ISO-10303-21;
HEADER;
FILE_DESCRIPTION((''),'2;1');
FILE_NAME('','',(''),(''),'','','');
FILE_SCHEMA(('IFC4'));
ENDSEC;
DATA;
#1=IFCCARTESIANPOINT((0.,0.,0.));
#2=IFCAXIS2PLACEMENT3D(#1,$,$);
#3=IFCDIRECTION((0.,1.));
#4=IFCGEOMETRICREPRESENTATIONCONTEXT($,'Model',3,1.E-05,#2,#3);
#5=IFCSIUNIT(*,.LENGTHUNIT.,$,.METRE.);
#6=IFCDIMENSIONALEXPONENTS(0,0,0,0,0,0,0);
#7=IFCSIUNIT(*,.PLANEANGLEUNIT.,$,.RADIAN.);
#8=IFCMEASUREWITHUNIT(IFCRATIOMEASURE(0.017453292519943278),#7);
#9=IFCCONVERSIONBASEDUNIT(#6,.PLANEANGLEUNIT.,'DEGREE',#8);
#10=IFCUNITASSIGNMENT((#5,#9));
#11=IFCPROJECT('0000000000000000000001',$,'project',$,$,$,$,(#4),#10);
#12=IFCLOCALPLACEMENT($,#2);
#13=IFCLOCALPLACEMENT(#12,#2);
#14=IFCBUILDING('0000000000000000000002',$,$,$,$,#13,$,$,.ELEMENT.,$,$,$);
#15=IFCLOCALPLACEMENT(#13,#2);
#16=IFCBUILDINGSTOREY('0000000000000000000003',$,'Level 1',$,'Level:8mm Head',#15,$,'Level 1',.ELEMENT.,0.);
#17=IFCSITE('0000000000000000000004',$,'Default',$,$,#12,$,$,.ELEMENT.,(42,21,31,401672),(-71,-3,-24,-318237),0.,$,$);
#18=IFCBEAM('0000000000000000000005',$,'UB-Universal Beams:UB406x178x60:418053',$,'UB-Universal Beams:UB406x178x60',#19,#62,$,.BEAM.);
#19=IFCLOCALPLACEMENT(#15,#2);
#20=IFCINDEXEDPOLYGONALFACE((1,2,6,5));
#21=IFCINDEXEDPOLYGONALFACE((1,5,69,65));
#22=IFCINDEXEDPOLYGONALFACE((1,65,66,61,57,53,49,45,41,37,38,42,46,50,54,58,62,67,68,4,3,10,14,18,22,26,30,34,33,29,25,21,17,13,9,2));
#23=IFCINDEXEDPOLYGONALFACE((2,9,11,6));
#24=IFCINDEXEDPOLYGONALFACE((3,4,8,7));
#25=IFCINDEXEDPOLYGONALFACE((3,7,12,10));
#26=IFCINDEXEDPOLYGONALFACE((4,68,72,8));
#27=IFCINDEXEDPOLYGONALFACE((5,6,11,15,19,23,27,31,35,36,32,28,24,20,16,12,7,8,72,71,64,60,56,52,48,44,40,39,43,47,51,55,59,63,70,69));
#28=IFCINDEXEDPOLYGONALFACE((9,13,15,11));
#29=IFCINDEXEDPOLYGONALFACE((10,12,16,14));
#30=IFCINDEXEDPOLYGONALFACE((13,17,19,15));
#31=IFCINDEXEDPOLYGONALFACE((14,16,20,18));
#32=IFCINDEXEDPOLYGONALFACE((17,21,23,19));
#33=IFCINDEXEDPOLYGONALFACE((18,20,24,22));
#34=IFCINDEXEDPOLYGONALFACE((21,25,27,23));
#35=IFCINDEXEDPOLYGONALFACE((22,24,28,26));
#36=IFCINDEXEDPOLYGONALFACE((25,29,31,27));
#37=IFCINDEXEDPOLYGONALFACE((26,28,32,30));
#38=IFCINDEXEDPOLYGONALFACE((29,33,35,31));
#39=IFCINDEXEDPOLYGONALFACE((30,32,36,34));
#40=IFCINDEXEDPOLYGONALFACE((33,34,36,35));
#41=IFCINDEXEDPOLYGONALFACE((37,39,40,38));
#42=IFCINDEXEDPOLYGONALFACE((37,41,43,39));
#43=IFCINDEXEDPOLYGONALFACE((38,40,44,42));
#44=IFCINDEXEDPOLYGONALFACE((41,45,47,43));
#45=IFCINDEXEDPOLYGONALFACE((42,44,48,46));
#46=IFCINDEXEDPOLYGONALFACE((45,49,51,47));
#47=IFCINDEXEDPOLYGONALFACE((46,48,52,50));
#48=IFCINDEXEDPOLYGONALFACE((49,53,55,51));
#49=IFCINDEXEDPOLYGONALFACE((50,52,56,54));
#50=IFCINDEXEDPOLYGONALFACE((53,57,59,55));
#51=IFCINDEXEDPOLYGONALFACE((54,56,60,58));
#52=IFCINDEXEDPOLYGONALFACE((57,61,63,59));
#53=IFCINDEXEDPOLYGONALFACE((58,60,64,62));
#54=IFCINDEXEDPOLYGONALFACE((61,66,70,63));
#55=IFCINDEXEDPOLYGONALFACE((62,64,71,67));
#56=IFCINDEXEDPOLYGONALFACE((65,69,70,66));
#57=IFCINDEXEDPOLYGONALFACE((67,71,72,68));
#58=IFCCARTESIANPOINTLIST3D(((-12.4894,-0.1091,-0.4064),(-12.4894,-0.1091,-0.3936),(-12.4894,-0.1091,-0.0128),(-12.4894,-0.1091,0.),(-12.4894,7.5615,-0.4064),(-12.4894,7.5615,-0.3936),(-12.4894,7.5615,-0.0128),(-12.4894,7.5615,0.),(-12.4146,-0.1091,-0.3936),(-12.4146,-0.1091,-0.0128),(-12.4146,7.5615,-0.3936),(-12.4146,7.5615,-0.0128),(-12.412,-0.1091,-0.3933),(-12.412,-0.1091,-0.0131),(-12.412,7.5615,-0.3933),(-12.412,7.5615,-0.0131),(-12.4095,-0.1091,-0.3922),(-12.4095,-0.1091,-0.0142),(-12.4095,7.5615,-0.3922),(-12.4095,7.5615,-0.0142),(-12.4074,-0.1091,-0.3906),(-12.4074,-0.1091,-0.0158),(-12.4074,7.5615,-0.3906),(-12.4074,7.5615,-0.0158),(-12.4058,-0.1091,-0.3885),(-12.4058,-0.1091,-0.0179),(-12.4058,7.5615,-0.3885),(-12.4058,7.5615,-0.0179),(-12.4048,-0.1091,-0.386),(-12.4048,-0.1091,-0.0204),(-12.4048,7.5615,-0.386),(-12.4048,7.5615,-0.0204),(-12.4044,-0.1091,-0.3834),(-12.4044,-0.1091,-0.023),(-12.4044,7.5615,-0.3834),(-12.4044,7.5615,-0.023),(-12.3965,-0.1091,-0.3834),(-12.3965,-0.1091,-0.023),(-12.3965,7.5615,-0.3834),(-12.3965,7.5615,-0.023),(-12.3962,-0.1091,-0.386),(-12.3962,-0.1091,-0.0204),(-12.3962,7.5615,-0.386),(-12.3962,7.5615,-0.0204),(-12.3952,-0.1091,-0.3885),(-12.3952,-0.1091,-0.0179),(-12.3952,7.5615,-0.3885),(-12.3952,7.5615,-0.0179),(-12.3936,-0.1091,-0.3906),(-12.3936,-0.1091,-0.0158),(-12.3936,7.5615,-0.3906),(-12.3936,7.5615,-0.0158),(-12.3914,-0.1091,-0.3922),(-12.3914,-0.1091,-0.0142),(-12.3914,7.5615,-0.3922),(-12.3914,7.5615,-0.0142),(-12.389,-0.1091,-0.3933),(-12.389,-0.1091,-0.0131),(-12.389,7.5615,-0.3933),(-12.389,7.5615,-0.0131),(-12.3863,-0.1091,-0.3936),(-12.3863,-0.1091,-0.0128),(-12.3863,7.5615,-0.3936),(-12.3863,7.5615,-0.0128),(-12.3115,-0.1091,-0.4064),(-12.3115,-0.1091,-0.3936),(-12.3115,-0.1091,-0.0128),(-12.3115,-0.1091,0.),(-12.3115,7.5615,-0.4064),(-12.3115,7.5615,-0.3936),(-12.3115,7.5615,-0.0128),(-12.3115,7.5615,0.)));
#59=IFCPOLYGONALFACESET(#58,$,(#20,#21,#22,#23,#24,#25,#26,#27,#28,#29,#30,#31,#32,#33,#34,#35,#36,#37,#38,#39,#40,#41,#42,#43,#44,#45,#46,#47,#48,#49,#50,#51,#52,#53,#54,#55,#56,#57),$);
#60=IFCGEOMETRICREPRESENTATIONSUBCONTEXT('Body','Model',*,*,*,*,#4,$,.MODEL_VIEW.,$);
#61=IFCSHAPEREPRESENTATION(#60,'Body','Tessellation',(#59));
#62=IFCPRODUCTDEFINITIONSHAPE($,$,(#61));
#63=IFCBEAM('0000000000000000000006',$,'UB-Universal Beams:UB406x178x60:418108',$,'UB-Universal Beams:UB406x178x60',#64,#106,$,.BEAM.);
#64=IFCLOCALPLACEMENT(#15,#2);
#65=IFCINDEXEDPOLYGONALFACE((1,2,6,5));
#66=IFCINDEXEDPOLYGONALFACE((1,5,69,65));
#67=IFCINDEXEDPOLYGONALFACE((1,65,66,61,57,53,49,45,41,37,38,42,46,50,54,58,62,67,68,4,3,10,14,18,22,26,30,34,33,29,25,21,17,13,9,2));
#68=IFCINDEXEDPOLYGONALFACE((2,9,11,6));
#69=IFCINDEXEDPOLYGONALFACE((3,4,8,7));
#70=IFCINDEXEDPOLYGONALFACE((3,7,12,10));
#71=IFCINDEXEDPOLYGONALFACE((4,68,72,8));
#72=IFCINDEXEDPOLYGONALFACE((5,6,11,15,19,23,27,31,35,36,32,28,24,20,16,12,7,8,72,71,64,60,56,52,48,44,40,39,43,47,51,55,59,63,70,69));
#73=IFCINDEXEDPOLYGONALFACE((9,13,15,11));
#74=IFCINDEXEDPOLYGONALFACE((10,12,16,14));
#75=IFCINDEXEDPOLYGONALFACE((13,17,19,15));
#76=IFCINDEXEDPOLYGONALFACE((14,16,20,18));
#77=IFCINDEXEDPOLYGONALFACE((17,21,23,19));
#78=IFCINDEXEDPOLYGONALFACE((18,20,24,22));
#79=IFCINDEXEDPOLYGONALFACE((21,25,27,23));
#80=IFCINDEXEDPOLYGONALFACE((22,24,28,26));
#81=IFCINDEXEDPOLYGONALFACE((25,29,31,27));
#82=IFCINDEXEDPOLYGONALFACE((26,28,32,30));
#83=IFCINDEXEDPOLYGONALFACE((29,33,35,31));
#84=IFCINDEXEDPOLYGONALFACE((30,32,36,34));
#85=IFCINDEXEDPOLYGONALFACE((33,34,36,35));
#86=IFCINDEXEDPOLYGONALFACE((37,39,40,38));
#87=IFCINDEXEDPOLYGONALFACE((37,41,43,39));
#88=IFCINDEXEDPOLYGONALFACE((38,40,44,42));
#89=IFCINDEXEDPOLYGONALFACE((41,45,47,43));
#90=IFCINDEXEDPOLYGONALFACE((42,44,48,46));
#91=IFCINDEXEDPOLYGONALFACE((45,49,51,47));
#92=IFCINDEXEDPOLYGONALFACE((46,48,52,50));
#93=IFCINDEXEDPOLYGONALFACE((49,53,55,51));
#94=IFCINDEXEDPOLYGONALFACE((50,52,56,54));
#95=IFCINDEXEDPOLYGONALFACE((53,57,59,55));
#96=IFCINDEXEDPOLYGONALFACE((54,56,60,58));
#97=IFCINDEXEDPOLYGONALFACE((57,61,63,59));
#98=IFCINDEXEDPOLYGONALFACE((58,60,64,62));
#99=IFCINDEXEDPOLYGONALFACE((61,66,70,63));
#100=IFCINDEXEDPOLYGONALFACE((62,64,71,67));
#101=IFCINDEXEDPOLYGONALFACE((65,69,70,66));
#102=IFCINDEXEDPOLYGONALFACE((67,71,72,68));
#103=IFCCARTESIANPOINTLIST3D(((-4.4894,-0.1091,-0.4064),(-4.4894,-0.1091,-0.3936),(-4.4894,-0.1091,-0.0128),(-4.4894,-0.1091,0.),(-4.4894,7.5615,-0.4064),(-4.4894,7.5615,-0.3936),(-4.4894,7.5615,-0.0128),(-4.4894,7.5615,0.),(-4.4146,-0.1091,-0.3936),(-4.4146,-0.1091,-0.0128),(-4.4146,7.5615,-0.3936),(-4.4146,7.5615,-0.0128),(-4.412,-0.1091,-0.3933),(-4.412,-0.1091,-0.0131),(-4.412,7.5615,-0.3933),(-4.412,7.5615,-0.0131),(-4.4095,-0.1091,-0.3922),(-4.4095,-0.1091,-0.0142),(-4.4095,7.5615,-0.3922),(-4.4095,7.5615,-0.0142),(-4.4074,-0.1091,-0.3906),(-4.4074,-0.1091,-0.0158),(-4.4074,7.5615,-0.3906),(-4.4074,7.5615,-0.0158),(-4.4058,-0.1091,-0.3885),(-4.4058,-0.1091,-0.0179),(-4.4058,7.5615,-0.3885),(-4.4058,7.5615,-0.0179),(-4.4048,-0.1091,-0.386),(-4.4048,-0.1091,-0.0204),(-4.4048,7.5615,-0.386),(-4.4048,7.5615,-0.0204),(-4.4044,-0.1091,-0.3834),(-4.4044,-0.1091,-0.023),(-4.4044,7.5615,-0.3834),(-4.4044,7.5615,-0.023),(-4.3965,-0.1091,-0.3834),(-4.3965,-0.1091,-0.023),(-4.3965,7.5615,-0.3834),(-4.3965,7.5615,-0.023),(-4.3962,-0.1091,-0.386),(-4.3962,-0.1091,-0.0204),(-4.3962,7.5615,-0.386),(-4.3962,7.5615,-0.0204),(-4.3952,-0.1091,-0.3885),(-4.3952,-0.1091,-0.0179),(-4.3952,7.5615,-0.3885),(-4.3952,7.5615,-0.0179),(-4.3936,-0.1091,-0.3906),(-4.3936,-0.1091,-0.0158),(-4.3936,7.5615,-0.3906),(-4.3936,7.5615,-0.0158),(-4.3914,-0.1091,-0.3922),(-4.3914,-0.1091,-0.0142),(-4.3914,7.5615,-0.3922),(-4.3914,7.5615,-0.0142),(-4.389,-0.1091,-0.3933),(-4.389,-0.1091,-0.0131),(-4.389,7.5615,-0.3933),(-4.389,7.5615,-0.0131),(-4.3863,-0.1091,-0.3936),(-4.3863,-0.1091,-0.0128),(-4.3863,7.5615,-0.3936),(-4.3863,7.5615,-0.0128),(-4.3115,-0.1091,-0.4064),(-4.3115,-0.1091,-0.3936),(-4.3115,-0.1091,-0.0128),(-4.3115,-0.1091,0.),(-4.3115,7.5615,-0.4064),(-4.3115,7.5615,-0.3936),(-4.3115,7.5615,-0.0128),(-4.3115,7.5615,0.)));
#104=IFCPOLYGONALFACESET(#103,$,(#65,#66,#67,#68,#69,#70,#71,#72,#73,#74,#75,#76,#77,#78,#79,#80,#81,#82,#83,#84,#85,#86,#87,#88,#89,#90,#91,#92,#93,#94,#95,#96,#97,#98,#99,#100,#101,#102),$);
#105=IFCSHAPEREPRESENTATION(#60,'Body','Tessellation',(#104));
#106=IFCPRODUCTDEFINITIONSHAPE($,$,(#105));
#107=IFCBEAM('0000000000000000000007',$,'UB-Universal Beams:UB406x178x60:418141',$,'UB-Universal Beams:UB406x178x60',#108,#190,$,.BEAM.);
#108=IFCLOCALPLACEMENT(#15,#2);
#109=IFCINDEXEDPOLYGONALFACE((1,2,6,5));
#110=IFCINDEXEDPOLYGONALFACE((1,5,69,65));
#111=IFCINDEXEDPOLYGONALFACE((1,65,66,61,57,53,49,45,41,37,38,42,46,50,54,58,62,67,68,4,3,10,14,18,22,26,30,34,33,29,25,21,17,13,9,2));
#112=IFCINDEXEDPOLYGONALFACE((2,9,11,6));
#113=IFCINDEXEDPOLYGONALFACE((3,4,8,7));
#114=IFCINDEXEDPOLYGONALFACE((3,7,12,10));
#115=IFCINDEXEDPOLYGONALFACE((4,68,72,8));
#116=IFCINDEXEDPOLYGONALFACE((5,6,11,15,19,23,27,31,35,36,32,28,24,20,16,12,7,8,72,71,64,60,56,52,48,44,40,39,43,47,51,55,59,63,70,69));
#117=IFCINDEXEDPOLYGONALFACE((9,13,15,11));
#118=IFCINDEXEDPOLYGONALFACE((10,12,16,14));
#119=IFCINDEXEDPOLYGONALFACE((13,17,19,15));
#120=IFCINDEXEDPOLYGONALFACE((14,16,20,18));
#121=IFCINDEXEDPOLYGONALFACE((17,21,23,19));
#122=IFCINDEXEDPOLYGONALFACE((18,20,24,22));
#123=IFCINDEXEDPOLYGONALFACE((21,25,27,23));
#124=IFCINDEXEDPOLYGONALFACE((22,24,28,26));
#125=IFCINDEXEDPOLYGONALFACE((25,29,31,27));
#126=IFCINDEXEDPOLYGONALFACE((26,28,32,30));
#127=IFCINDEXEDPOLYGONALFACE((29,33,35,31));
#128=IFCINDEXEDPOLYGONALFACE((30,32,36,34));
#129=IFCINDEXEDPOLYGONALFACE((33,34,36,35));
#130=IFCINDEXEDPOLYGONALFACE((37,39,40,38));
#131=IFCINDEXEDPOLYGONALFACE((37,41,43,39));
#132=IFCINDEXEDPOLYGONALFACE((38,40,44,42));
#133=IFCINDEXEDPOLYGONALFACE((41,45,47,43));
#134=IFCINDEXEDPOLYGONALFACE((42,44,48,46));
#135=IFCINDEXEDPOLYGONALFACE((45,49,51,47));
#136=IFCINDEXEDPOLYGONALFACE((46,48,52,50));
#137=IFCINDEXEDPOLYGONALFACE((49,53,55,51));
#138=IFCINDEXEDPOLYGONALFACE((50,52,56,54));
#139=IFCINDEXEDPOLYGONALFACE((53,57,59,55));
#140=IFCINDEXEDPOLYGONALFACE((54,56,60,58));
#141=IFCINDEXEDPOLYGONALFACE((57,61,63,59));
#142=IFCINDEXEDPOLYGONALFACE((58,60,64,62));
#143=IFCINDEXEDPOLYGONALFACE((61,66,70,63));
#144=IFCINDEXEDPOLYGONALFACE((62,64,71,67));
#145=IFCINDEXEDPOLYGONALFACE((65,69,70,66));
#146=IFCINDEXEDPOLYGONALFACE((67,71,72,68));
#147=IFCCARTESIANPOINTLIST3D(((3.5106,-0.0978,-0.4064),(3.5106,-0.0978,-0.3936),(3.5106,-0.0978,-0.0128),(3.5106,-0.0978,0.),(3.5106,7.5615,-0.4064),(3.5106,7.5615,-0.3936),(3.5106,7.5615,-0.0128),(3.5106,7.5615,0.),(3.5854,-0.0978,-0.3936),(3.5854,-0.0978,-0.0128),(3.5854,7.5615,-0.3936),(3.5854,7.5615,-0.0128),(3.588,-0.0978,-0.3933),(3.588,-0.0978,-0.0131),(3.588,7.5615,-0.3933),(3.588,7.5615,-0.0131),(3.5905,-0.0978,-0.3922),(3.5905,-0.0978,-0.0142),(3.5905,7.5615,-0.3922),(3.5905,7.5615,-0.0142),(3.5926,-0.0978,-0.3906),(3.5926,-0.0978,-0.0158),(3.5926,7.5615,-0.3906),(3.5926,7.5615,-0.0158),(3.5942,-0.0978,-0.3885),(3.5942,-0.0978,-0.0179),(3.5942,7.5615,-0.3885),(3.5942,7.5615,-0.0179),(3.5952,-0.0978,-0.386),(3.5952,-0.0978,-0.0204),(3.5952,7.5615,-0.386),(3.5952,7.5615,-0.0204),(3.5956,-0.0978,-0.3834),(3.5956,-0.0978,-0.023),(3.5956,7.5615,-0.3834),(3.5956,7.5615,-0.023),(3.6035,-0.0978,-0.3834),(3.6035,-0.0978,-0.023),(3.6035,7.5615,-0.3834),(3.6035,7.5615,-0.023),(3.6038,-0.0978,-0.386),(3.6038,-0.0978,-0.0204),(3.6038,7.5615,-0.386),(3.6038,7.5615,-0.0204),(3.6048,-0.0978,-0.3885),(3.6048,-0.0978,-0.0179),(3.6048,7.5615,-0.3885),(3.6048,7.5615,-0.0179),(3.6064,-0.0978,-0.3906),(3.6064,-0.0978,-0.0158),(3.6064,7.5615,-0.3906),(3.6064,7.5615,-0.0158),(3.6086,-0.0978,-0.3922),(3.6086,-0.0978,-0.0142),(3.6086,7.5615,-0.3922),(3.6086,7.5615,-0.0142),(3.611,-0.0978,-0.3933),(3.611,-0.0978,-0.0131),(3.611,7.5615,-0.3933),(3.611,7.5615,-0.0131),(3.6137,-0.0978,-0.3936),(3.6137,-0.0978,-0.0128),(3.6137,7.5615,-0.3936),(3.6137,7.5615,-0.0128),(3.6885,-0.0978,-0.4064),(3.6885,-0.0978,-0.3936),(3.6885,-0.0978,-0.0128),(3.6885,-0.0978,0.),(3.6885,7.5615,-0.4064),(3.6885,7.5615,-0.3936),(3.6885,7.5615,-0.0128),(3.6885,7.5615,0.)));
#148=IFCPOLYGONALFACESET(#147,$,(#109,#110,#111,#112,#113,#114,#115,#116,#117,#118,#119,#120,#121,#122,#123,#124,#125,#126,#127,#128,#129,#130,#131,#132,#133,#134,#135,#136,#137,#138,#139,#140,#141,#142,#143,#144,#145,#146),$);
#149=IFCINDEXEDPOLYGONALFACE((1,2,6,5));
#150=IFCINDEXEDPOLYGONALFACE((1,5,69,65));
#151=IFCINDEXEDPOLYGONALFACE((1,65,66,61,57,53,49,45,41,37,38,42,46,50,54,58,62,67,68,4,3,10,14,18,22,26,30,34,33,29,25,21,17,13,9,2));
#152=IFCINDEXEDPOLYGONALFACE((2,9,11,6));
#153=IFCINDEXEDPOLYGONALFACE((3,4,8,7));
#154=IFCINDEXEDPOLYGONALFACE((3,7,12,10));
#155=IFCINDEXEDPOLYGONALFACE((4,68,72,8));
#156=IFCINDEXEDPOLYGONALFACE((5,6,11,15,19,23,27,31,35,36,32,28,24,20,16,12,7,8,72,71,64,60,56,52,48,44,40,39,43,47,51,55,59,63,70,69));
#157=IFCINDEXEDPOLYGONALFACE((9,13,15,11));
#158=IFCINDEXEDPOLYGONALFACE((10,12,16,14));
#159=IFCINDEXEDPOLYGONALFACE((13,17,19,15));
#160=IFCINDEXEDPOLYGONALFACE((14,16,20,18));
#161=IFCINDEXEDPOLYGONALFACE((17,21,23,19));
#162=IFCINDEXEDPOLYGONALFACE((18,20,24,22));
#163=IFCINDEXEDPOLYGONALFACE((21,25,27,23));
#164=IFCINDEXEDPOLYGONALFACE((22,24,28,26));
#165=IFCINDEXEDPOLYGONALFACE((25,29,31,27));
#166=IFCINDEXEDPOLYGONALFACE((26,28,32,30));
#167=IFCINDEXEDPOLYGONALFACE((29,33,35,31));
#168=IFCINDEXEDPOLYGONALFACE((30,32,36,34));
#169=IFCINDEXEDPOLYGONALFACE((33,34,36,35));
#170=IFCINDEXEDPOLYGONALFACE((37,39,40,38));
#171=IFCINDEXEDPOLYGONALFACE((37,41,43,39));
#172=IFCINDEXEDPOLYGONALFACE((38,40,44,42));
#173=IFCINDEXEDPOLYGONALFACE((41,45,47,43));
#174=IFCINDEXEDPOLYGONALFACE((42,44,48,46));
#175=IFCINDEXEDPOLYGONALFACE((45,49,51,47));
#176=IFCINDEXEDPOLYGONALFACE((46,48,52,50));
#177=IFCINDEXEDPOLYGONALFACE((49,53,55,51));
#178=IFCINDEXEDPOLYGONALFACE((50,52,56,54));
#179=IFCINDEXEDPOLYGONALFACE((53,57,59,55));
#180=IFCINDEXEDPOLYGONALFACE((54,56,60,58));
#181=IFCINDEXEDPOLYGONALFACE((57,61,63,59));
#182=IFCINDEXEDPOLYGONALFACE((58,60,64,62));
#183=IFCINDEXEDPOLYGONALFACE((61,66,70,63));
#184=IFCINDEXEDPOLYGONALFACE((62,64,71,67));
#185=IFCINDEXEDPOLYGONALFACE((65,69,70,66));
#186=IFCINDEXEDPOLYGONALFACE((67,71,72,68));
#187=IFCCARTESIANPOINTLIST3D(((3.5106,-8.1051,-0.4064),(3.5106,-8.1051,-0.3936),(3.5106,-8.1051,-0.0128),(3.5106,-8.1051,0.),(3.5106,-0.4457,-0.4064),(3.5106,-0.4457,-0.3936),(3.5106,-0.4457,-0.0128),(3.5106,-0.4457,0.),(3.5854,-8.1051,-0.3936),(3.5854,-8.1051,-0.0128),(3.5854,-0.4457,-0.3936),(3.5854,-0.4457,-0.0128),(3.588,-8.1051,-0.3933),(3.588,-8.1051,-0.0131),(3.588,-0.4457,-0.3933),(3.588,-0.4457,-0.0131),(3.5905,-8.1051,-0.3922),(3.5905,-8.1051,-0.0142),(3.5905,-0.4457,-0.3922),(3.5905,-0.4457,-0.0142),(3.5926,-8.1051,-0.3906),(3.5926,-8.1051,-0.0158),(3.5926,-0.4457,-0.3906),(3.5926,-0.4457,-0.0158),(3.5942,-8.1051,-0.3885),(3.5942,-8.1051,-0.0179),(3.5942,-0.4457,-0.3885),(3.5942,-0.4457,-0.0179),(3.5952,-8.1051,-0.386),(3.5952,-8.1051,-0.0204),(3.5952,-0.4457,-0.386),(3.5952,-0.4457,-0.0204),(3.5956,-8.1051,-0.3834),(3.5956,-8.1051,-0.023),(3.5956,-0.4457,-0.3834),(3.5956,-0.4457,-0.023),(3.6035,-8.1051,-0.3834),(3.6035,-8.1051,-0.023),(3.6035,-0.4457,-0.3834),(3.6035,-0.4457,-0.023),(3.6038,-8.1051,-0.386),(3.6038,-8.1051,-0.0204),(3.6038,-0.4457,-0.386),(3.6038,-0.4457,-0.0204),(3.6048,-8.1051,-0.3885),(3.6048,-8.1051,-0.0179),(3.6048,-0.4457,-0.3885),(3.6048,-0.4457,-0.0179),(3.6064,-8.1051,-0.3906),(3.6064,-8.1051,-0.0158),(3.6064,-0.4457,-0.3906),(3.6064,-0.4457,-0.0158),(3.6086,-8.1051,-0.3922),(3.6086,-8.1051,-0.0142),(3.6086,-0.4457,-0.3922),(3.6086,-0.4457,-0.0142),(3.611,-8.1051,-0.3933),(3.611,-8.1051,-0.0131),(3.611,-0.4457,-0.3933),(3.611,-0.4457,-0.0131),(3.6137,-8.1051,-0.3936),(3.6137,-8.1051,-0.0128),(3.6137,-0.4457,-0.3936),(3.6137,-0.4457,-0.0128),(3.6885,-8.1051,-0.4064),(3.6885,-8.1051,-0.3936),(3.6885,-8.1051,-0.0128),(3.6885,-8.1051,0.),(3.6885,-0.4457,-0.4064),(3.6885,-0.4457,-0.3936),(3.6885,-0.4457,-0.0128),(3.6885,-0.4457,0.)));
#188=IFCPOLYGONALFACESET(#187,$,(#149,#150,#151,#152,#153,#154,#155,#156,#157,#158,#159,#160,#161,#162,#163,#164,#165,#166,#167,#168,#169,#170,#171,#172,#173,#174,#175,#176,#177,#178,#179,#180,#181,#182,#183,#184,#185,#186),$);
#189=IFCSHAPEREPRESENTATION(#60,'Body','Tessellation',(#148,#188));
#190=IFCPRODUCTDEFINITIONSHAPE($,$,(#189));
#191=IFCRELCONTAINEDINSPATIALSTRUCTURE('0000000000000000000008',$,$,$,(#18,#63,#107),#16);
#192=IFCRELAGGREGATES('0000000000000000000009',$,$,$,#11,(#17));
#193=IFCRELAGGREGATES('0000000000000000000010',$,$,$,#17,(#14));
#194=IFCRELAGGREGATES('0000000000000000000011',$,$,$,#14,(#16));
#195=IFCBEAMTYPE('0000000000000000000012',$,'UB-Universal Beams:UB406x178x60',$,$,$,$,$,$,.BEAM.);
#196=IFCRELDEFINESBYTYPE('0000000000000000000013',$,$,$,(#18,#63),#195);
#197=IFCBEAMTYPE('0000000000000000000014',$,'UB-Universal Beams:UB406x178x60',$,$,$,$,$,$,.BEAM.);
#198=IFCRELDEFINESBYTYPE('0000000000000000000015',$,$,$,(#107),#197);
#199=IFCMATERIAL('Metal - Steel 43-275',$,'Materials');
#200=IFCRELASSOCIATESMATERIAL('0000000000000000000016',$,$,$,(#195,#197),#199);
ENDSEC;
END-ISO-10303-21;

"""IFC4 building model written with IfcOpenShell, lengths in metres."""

from ifc_helpers import new_model, entity, si_unit, converted_unit, direction, frame, frame_2d, origin, place, context, subcontext, project, spatial, i_section, extrude, source, transform, mapped, material, material_profile, profile_set, type_object, type_shapes, element, save


model = new_model("IFC4")

# Units and contexts
model_context = context("Model", 3, precision=1e-05, world=origin(), true_north=direction((0.0, 1.0)))
body_context = subcontext(model_context, "Body", "Model", "MODEL_VIEW")
ifc_project = project(units=[si_unit("LENGTHUNIT", "METRE"), converted_unit("PLANEANGLEUNIT", "DEGREE", entity("IfcRatioMeasure", 0.017453292519943278), si_unit("PLANEANGLEUNIT", "RADIAN"), dimensions=[0, 0, 0, 0, 0, 0, 0])], contexts=[model_context])

# Site, building, storey
site_placement = place(None, origin())
site = spatial("IfcSite", under=ifc_project, at=site_placement, Name="Default", CompositionType="ELEMENT", RefLatitude=(42, 21, 31, 401672), RefLongitude=(-71, -3, -24, -318237), RefElevation=0.0)
building_placement = place(site_placement, origin())
building = spatial("IfcBuilding", under=site, at=building_placement, CompositionType="ELEMENT")
storey_placement = place(building_placement, origin())
storey = spatial("IfcBuildingStorey", under=building, at=storey_placement, Name="Level 1", ObjectType="Level:8mm Head", LongName="Level 1", CompositionType="ELEMENT", Elevation=0.0)

# Beams
ifc_material_1 = material(Name="Metal - Steel 43-275", Category="Materials")
ifc_material_profile_1 = material_profile(ifc_material_1, i_section(OverallWidth=0.1779, OverallDepth=0.4064, WebThickness=0.0079, FlangeThickness=0.0128, FilletRadius=0.0102, at=frame_2d((0.0, 0.0), x_axis=(0.0, 1.0))), Name="UB406x178x60")
ifc_profile_set_1 = profile_set([ifc_material_profile_1], Name="UB406x178x60")
beam_type_1 = type_object("IfcBeamType", Name="UB-Universal Beams:UB406x178x60", PredefinedType="BEAM", material=ifc_profile_set_1)
shared_shape_1 = source(origin(), body_context, "Body", "SweptSolid", [
    extrude(i_section(OverallWidth=0.1779, OverallDepth=0.4064, WebThickness=0.0079, FlangeThickness=0.0128, FilletRadius=0.0102, at=frame_2d((0.0, 0.0), x_axis=(0.0, 1.0))), frame((-3.8373, 0.0, 0.0), z_axis=(1.0, 0.0, 0.0), x_axis=(0.0, 0.0, -1.0)), (0.0, 0.0, 1.0), 7.6706),
])
type_shapes(beam_type_1, [shared_shape_1])
for number, where, z_axis, x_axis, name in (
    (1, (-12.4005, 3.7282, -0.2032), (0.0, 0.0, 1.0), (0.0, 1.0, 0.0), "UB-Universal Beams:UB406x178x60:418053"),
    (2, (-4.4005, 3.7282, -0.2032), (0.0, 0.0, 1.0), (0.0, 1.0, 0.0), "UB-Universal Beams:UB406x178x60:418108"),
):
    element("IfcBeam", number, at=place(storey_placement, frame(where, z_axis=z_axis, x_axis=x_axis)), inside=storey, type_object=beam_type_1, Name=name, ObjectType="UB-Universal Beams:UB406x178x60", PredefinedType="BEAM", context=body_context, shape_type="MappedRepresentation", body=[
        mapped(shared_shape_1, transform((0.0, 0.0, 0.0), scale=1.0)),
    ])
beam_type_2 = type_object("IfcBeamType", Name="UB-Universal Beams:UB406x178x60", PredefinedType="BEAM", material=ifc_profile_set_1)
shared_shape_2 = source(origin(), body_context, "Body", "SweptSolid", [
    extrude(i_section(OverallWidth=0.1779, OverallDepth=0.4064, WebThickness=0.0079, FlangeThickness=0.0128, FilletRadius=0.0102, at=frame_2d((0.0, 0.0), x_axis=(1.0, 0.0))), frame((3.5995, -0.0978, -0.2032), z_axis=(0.0, 1.0, 0.0), x_axis=(-1.0, 0.0, 0.0)), (0.0, 0.0, 1.0), 7.6594),
    extrude(i_section(OverallWidth=0.1779, OverallDepth=0.4064, WebThickness=0.0079, FlangeThickness=0.0128, FilletRadius=0.0102, at=frame_2d((0.0, 0.0), x_axis=(1.0, 0.0))), frame((3.5995, -8.1051, -0.2032), z_axis=(0.0, 1.0, 0.0), x_axis=(-1.0, 0.0, 0.0)), (0.0, 0.0, 1.0), 7.6594),
])
type_shapes(beam_type_2, [shared_shape_2])
beam_1_placement = place(storey_placement, origin())
element("IfcBeam", 3, at=beam_1_placement, inside=storey, type_object=beam_type_2, Name="UB-Universal Beams:UB406x178x60:418141", ObjectType="UB-Universal Beams:UB406x178x60", PredefinedType="BEAM", context=body_context, shape_type="MappedRepresentation", body=[
    mapped(shared_shape_2, transform((0.0, 0.0, 0.0), scale=1.0)),
])

save(model, "model.ifc")
